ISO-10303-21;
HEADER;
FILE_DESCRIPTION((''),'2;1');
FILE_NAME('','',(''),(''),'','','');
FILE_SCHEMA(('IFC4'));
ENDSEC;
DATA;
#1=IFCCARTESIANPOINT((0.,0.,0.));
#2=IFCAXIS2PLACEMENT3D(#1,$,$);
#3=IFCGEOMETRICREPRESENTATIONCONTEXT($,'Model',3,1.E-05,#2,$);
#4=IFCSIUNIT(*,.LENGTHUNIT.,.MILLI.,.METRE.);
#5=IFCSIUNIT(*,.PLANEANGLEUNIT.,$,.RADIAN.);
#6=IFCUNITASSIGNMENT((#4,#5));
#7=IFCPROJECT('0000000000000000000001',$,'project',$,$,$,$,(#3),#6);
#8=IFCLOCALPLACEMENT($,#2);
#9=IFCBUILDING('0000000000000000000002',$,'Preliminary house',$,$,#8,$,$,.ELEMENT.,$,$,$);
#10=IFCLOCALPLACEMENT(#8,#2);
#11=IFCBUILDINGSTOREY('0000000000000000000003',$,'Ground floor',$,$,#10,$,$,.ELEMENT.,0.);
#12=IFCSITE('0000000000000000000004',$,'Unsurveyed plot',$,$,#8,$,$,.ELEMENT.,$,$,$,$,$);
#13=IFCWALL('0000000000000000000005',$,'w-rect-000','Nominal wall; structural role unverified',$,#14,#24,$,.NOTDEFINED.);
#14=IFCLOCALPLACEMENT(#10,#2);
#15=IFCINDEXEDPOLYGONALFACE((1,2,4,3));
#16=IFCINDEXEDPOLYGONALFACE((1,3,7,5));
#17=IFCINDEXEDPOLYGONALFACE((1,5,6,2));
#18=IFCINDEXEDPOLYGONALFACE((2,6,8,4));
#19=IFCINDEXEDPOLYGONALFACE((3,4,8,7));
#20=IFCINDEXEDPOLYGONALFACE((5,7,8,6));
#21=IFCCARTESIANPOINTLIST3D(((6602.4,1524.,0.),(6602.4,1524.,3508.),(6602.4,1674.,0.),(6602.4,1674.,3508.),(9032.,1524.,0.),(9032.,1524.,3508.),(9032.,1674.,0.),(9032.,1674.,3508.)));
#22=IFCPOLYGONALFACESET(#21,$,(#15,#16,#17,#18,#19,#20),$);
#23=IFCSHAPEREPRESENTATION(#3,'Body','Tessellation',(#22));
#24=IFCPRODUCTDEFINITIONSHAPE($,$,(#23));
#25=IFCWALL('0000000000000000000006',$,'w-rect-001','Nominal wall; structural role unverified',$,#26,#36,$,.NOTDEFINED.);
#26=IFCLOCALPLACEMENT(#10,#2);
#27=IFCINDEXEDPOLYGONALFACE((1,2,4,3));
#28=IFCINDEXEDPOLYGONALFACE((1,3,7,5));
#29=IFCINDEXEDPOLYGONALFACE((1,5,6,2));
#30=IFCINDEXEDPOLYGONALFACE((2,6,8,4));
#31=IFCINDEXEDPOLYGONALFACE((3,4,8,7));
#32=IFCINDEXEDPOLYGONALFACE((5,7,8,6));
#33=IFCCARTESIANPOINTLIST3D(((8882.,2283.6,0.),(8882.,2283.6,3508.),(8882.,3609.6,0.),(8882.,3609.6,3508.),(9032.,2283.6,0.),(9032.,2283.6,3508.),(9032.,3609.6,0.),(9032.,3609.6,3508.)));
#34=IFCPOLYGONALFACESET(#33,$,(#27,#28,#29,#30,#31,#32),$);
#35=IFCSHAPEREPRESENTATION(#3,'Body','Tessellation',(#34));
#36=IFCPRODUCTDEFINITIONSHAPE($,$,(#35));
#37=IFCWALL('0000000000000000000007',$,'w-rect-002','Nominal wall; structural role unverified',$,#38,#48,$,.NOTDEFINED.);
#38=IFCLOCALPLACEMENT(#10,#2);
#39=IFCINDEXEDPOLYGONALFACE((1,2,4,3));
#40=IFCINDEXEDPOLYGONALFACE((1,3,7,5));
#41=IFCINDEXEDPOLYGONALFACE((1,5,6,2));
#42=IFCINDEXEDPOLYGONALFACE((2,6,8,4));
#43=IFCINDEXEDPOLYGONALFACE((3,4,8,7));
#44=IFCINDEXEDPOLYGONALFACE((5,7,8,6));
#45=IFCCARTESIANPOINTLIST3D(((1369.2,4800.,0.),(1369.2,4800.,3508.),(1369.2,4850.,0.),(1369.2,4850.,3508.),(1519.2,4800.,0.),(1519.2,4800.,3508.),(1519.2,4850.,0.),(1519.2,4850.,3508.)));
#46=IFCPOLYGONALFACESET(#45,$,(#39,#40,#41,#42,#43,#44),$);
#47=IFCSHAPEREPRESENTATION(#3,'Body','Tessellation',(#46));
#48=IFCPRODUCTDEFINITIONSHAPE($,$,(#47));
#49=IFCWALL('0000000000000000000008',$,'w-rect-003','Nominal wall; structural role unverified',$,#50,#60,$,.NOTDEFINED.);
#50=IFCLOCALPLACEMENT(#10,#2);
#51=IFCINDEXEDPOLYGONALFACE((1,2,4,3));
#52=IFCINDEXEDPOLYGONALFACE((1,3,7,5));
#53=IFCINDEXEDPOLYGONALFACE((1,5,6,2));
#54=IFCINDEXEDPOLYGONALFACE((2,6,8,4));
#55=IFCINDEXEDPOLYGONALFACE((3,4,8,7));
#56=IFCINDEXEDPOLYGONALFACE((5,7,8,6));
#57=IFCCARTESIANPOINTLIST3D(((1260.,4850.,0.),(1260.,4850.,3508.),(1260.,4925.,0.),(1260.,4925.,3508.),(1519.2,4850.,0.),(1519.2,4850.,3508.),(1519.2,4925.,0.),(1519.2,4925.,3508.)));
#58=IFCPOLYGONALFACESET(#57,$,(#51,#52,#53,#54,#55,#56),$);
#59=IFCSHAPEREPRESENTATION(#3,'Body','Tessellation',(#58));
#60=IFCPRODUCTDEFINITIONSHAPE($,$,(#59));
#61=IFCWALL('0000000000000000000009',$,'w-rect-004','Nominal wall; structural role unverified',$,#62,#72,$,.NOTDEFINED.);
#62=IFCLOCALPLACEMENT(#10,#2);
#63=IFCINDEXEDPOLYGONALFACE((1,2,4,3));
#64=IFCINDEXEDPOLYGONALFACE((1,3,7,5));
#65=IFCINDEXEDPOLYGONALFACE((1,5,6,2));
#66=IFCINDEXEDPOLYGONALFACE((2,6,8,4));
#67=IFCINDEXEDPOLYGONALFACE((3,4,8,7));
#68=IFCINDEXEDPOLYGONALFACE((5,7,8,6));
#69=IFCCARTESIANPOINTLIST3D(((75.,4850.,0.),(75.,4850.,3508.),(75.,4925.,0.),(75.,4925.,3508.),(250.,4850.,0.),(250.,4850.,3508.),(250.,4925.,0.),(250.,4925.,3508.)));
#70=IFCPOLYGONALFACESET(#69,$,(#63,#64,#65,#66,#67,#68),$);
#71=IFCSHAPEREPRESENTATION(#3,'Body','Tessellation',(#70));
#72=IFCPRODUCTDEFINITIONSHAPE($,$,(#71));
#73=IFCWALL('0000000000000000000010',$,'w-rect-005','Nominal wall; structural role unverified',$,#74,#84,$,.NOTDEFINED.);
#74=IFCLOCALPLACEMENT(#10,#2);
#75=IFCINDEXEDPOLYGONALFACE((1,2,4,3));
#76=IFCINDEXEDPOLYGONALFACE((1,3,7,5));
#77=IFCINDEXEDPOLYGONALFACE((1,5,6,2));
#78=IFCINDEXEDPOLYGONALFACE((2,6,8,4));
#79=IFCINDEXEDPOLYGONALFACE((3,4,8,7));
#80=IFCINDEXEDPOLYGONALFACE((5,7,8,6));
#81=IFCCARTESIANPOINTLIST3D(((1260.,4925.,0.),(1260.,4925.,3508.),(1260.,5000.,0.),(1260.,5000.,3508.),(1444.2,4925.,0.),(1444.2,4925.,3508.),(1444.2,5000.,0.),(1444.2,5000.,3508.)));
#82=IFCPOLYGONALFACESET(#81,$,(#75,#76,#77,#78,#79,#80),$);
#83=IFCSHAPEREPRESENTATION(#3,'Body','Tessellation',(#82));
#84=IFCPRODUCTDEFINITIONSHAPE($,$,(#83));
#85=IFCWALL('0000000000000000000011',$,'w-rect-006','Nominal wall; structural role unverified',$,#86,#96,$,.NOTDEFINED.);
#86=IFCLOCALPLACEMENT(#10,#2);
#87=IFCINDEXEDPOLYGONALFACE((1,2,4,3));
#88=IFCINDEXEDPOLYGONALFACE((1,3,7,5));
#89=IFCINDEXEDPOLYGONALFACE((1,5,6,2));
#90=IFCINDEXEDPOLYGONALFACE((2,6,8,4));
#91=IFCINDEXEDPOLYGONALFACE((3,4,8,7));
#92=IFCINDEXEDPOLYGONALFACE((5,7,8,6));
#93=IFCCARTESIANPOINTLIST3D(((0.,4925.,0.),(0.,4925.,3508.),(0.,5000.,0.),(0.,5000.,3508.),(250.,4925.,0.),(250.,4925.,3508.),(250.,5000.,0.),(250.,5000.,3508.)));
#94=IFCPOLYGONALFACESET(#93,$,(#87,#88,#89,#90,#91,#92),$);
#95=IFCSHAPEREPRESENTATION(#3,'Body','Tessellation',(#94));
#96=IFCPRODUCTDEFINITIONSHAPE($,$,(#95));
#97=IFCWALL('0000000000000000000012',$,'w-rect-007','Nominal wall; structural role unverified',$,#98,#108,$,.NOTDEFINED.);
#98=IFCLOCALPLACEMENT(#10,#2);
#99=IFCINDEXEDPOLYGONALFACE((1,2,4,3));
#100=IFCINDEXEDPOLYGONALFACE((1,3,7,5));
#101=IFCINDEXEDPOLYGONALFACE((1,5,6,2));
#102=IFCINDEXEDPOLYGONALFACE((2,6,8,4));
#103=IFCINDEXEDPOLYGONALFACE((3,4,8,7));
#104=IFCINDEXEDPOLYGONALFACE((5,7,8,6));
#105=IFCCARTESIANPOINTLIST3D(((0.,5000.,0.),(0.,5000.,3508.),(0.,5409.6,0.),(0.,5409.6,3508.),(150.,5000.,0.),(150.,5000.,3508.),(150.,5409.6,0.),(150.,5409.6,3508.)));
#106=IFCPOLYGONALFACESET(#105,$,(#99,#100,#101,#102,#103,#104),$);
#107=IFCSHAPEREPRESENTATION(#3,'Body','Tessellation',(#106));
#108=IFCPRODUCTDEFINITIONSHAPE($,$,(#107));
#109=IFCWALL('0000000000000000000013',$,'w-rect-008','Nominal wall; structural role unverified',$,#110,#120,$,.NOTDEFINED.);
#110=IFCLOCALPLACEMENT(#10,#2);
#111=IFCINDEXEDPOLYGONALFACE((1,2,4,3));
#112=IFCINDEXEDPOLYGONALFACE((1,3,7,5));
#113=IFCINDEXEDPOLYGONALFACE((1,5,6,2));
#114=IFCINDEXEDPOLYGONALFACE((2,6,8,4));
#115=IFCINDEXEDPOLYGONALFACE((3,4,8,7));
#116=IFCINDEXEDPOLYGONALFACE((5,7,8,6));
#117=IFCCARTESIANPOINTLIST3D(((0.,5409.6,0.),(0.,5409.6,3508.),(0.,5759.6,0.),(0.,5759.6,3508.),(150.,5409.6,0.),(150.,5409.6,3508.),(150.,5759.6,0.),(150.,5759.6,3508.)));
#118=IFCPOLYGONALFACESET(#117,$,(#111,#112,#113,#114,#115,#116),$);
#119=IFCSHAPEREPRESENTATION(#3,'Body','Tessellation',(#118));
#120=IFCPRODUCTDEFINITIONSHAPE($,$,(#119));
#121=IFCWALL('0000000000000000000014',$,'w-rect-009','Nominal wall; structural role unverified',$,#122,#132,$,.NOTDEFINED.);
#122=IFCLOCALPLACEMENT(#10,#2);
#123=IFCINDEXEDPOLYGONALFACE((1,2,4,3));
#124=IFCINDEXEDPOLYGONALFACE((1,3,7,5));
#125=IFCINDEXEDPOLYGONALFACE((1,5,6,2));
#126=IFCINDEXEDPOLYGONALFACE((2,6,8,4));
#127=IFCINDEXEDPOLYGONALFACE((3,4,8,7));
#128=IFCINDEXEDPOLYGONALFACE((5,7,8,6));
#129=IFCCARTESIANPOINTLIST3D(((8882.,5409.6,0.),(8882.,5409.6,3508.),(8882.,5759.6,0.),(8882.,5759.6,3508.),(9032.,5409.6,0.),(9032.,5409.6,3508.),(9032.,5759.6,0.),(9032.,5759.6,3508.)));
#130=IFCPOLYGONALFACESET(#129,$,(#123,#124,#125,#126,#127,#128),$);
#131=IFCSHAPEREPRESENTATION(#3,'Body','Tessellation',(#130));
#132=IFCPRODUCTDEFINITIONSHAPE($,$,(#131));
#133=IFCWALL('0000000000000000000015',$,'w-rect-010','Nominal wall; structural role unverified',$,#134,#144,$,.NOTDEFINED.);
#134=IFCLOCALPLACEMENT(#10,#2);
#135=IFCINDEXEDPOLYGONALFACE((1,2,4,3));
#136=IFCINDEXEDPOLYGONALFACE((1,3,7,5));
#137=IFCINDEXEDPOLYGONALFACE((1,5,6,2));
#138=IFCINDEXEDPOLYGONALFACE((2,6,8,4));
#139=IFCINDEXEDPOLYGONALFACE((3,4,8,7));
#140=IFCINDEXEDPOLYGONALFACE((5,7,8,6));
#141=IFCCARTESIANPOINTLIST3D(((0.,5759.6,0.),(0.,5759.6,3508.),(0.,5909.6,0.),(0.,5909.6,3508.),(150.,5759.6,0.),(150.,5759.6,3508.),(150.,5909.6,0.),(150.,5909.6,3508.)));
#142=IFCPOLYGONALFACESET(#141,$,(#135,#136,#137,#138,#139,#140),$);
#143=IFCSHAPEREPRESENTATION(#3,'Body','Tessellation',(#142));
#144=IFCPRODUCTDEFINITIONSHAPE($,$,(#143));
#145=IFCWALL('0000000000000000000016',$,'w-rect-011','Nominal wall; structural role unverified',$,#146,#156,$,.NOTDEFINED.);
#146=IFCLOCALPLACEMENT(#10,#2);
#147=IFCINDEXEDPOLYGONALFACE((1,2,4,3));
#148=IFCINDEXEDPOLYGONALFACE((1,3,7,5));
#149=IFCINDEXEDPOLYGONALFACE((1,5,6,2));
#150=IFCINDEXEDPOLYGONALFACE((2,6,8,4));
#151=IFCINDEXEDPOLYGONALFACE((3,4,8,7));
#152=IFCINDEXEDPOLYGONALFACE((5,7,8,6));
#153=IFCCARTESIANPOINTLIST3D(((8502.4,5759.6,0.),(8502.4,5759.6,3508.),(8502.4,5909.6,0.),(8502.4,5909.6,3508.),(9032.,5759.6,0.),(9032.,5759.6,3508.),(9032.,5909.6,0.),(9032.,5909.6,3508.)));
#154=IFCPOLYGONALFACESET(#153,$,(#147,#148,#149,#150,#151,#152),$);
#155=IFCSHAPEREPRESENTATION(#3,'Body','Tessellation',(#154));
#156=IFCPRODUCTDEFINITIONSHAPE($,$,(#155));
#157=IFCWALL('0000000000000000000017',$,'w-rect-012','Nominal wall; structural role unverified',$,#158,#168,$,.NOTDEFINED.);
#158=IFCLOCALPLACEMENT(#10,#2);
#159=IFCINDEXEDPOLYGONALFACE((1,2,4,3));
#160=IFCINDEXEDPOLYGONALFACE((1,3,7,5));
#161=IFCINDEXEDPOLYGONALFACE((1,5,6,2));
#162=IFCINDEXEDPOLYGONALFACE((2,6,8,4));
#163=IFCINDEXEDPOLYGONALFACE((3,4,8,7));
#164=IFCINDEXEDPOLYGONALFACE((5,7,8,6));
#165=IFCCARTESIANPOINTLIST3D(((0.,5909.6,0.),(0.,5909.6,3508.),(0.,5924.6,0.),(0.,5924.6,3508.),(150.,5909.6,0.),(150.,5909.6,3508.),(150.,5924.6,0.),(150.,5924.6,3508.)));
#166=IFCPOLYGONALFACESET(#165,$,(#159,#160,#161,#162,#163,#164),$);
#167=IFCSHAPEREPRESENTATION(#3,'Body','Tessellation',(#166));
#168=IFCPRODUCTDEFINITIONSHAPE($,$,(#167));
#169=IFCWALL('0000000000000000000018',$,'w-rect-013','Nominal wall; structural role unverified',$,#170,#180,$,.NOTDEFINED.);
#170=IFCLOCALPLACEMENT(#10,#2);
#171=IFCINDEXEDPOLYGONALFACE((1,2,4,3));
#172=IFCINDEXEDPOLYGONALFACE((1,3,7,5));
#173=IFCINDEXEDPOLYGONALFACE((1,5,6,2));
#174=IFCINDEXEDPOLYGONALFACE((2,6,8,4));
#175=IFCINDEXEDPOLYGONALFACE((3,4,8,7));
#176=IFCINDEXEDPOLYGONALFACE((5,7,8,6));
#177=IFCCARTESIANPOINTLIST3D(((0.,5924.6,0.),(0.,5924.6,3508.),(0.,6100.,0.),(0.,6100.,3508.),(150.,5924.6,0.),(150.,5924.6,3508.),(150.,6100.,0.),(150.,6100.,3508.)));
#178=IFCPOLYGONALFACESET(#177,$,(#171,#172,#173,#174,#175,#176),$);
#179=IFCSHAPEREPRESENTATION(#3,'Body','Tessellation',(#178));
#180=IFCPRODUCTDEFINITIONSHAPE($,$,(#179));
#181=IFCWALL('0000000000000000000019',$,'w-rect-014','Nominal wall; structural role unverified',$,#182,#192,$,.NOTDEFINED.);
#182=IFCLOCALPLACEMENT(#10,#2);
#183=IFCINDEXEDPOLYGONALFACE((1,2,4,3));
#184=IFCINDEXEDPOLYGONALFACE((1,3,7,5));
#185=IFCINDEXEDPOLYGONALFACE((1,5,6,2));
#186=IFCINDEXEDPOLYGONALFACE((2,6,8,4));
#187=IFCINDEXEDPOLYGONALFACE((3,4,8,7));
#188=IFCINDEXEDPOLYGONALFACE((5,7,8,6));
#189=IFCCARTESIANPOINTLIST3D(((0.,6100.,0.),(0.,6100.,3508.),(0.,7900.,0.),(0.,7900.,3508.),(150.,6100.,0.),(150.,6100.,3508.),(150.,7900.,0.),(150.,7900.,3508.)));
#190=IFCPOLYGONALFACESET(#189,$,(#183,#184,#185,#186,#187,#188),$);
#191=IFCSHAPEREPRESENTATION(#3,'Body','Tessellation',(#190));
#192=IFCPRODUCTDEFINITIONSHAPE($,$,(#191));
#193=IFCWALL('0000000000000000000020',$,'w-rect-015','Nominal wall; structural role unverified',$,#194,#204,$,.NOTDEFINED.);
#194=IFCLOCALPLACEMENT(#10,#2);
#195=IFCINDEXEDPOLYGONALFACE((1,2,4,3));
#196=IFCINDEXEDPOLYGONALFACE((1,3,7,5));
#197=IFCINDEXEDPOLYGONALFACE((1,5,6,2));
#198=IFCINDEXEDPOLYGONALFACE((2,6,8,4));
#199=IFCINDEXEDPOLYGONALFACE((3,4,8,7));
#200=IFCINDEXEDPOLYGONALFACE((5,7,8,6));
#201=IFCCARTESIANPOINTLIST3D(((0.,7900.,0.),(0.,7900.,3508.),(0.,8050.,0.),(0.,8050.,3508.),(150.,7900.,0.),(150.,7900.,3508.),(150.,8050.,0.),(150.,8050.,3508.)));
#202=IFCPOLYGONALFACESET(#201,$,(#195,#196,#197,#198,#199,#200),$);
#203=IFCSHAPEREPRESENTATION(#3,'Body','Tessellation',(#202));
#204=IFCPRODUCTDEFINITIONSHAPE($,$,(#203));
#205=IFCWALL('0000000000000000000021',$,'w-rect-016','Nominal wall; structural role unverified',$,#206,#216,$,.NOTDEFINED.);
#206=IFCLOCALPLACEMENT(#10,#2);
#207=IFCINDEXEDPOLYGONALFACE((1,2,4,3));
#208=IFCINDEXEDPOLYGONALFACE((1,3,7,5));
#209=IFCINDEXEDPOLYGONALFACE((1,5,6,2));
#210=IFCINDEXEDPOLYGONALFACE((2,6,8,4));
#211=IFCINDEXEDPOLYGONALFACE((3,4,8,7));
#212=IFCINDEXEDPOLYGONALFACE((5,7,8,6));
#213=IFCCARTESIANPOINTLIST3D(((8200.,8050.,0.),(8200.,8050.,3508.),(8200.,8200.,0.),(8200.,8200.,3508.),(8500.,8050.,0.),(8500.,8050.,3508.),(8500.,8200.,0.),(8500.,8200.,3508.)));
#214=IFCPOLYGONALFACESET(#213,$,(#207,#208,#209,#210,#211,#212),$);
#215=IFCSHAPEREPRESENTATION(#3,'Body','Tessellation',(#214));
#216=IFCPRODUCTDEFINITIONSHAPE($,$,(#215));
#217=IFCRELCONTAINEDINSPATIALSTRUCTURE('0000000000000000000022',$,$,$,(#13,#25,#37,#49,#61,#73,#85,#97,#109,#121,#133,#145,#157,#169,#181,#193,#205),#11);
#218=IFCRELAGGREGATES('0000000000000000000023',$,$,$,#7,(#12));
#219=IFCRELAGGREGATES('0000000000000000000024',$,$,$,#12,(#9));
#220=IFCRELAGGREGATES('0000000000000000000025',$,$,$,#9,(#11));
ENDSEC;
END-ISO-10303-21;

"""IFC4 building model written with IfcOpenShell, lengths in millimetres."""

from ifc_helpers import new_model, si_unit, origin, place, context, project, spatial, polyline, outline, extrude, element, save


model = new_model("IFC4")

# Units and contexts
model_context = context("Model", 3, precision=1e-05, world=origin())
ifc_project = project(units=[si_unit("LENGTHUNIT", "METRE", prefix="MILLI"), si_unit("PLANEANGLEUNIT", "RADIAN")], contexts=[model_context])

# Site, building, storey
placement_1 = place(None, origin())
site = spatial("IfcSite", under=ifc_project, at=placement_1, Name="Unsurveyed plot", CompositionType="ELEMENT")
building = spatial("IfcBuilding", under=site, at=placement_1, Name="Preliminary house", CompositionType="ELEMENT")
placement_2 = place(placement_1, origin())
storey = spatial("IfcBuildingStorey", under=building, at=placement_2, Name="Ground floor", CompositionType="ELEMENT", Elevation=0.0)

# Walls
element("IfcWall", 1, at=placement_2, inside=storey, Name="w-rect-000", Description="Nominal wall; structural role unverified", PredefinedType="NOTDEFINED", context=model_context, shape_type="SweptSolid", body=[
    extrude(outline(polyline([(6602.4, 1524.0), (9032.0, 1524.0), (9032.0, 1674.0), (6602.4, 1674.0), (6602.4, 1524.0)])), origin(), (0.0, 0.0, 1.0), 3508.0),
])
element("IfcWall", 2, at=placement_2, inside=storey, Name="w-rect-001", Description="Nominal wall; structural role unverified", PredefinedType="NOTDEFINED", context=model_context, shape_type="SweptSolid", body=[
    extrude(outline(polyline([(8882.0, 2283.6), (9032.0, 2283.6), (9032.0, 3609.6), (8882.0, 3609.6), (8882.0, 2283.6)])), origin(), (0.0, 0.0, 1.0), 3508.0),
])
element("IfcWall", 3, at=placement_2, inside=storey, Name="w-rect-002", Description="Nominal wall; structural role unverified", PredefinedType="NOTDEFINED", context=model_context, shape_type="SweptSolid", body=[
    extrude(outline(polyline([(1369.2, 4800.0), (1519.2, 4800.0), (1519.2, 4850.0), (1369.2, 4850.0), (1369.2, 4800.0)])), origin(), (0.0, 0.0, 1.0), 3508.0),
])
element("IfcWall", 4, at=placement_2, inside=storey, Name="w-rect-003", Description="Nominal wall; structural role unverified", PredefinedType="NOTDEFINED", context=model_context, shape_type="SweptSolid", body=[
    extrude(outline(polyline([(1260.0, 4850.0), (1519.2, 4850.0), (1519.2, 4925.0), (1260.0, 4925.0), (1260.0, 4850.0)])), origin(), (0.0, 0.0, 1.0), 3508.0),
])
element("IfcWall", 5, at=placement_2, inside=storey, Name="w-rect-004", Description="Nominal wall; structural role unverified", PredefinedType="NOTDEFINED", context=model_context, shape_type="SweptSolid", body=[
    extrude(outline(polyline([(75.0, 4850.0), (250.0, 4850.0), (250.0, 4925.0), (75.0, 4925.0), (75.0, 4850.0)])), origin(), (0.0, 0.0, 1.0), 3508.0),
])
element("IfcWall", 6, at=placement_2, inside=storey, Name="w-rect-005", Description="Nominal wall; structural role unverified", PredefinedType="NOTDEFINED", context=model_context, shape_type="SweptSolid", body=[
    extrude(outline(polyline([(1260.0, 4925.0), (1444.2, 4925.0), (1444.2, 5000.0), (1260.0, 5000.0), (1260.0, 4925.0)])), origin(), (0.0, 0.0, 1.0), 3508.0),
])
element("IfcWall", 7, at=placement_2, inside=storey, Name="w-rect-006", Description="Nominal wall; structural role unverified", PredefinedType="NOTDEFINED", context=model_context, shape_type="SweptSolid", body=[
    extrude(outline(polyline([(0.0, 4925.0), (250.0, 4925.0), (250.0, 5000.0), (0.0, 5000.0), (0.0, 4925.0)])), origin(), (0.0, 0.0, 1.0), 3508.0),
])
element("IfcWall", 8, at=placement_2, inside=storey, Name="w-rect-007", Description="Nominal wall; structural role unverified", PredefinedType="NOTDEFINED", context=model_context, shape_type="SweptSolid", body=[
    extrude(outline(polyline([(0.0, 5000.0), (150.0, 5000.0), (150.0, 5409.6), (0.0, 5409.6), (0.0, 5000.0)])), origin(), (0.0, 0.0, 1.0), 3508.0),
])
element("IfcWall", 9, at=placement_2, inside=storey, Name="w-rect-008", Description="Nominal wall; structural role unverified", PredefinedType="NOTDEFINED", context=model_context, shape_type="SweptSolid", body=[
    extrude(outline(polyline([(0.0, 5409.6), (150.0, 5409.6), (150.0, 5759.6), (0.0, 5759.6), (0.0, 5409.6)])), origin(), (0.0, 0.0, 1.0), 3508.0),
])
element("IfcWall", 10, at=placement_2, inside=storey, Name="w-rect-009", Description="Nominal wall; structural role unverified", PredefinedType="NOTDEFINED", context=model_context, shape_type="SweptSolid", body=[
    extrude(outline(polyline([(8882.0, 5409.6), (9032.0, 5409.6), (9032.0, 5759.6), (8882.0, 5759.6), (8882.0, 5409.6)])), origin(), (0.0, 0.0, 1.0), 3508.0),
])
element("IfcWall", 11, at=placement_2, inside=storey, Name="w-rect-010", Description="Nominal wall; structural role unverified", PredefinedType="NOTDEFINED", context=model_context, shape_type="SweptSolid", body=[
    extrude(outline(polyline([(0.0, 5759.6), (150.0, 5759.6), (150.0, 5909.6), (0.0, 5909.6), (0.0, 5759.6)])), origin(), (0.0, 0.0, 1.0), 3508.0),
])
element("IfcWall", 12, at=placement_2, inside=storey, Name="w-rect-011", Description="Nominal wall; structural role unverified", PredefinedType="NOTDEFINED", context=model_context, shape_type="SweptSolid", body=[
    extrude(outline(polyline([(8502.4, 5759.6), (9032.0, 5759.6), (9032.0, 5909.6), (8502.4, 5909.6), (8502.4, 5759.6)])), origin(), (0.0, 0.0, 1.0), 3508.0),
])
element("IfcWall", 13, at=placement_2, inside=storey, Name="w-rect-012", Description="Nominal wall; structural role unverified", PredefinedType="NOTDEFINED", context=model_context, shape_type="SweptSolid", body=[
    extrude(outline(polyline([(0.0, 5909.6), (150.0, 5909.6), (150.0, 5924.6), (0.0, 5924.6), (0.0, 5909.6)])), origin(), (0.0, 0.0, 1.0), 3508.0),
])
element("IfcWall", 14, at=placement_2, inside=storey, Name="w-rect-013", Description="Nominal wall; structural role unverified", PredefinedType="NOTDEFINED", context=model_context, shape_type="SweptSolid", body=[
    extrude(outline(polyline([(0.0, 5924.6), (150.0, 5924.6), (150.0, 6100.0), (0.0, 6100.0), (0.0, 5924.6)])), origin(), (0.0, 0.0, 1.0), 3508.0),
])
element("IfcWall", 15, at=placement_2, inside=storey, Name="w-rect-014", Description="Nominal wall; structural role unverified", PredefinedType="NOTDEFINED", context=model_context, shape_type="SweptSolid", body=[
    extrude(outline(polyline([(0.0, 6100.0), (150.0, 6100.0), (150.0, 7900.0), (0.0, 7900.0), (0.0, 6100.0)])), origin(), (0.0, 0.0, 1.0), 3508.0),
])
element("IfcWall", 16, at=placement_2, inside=storey, Name="w-rect-015", Description="Nominal wall; structural role unverified", PredefinedType="NOTDEFINED", context=model_context, shape_type="SweptSolid", body=[
    extrude(outline(polyline([(0.0, 7900.0), (150.0, 7900.0), (150.0, 8050.0), (0.0, 8050.0), (0.0, 7900.0)])), origin(), (0.0, 0.0, 1.0), 3508.0),
])
element("IfcWall", 17, at=placement_2, inside=storey, Name="w-rect-016", Description="Nominal wall; structural role unverified", PredefinedType="NOTDEFINED", context=model_context, shape_type="SweptSolid", body=[
    extrude(outline(polyline([(8200.0, 8050.0), (8500.0, 8050.0), (8500.0, 8200.0), (8200.0, 8200.0), (8200.0, 8050.0)])), origin(), (0.0, 0.0, 1.0), 3508.0),
])

save(model, "model.ifc")
